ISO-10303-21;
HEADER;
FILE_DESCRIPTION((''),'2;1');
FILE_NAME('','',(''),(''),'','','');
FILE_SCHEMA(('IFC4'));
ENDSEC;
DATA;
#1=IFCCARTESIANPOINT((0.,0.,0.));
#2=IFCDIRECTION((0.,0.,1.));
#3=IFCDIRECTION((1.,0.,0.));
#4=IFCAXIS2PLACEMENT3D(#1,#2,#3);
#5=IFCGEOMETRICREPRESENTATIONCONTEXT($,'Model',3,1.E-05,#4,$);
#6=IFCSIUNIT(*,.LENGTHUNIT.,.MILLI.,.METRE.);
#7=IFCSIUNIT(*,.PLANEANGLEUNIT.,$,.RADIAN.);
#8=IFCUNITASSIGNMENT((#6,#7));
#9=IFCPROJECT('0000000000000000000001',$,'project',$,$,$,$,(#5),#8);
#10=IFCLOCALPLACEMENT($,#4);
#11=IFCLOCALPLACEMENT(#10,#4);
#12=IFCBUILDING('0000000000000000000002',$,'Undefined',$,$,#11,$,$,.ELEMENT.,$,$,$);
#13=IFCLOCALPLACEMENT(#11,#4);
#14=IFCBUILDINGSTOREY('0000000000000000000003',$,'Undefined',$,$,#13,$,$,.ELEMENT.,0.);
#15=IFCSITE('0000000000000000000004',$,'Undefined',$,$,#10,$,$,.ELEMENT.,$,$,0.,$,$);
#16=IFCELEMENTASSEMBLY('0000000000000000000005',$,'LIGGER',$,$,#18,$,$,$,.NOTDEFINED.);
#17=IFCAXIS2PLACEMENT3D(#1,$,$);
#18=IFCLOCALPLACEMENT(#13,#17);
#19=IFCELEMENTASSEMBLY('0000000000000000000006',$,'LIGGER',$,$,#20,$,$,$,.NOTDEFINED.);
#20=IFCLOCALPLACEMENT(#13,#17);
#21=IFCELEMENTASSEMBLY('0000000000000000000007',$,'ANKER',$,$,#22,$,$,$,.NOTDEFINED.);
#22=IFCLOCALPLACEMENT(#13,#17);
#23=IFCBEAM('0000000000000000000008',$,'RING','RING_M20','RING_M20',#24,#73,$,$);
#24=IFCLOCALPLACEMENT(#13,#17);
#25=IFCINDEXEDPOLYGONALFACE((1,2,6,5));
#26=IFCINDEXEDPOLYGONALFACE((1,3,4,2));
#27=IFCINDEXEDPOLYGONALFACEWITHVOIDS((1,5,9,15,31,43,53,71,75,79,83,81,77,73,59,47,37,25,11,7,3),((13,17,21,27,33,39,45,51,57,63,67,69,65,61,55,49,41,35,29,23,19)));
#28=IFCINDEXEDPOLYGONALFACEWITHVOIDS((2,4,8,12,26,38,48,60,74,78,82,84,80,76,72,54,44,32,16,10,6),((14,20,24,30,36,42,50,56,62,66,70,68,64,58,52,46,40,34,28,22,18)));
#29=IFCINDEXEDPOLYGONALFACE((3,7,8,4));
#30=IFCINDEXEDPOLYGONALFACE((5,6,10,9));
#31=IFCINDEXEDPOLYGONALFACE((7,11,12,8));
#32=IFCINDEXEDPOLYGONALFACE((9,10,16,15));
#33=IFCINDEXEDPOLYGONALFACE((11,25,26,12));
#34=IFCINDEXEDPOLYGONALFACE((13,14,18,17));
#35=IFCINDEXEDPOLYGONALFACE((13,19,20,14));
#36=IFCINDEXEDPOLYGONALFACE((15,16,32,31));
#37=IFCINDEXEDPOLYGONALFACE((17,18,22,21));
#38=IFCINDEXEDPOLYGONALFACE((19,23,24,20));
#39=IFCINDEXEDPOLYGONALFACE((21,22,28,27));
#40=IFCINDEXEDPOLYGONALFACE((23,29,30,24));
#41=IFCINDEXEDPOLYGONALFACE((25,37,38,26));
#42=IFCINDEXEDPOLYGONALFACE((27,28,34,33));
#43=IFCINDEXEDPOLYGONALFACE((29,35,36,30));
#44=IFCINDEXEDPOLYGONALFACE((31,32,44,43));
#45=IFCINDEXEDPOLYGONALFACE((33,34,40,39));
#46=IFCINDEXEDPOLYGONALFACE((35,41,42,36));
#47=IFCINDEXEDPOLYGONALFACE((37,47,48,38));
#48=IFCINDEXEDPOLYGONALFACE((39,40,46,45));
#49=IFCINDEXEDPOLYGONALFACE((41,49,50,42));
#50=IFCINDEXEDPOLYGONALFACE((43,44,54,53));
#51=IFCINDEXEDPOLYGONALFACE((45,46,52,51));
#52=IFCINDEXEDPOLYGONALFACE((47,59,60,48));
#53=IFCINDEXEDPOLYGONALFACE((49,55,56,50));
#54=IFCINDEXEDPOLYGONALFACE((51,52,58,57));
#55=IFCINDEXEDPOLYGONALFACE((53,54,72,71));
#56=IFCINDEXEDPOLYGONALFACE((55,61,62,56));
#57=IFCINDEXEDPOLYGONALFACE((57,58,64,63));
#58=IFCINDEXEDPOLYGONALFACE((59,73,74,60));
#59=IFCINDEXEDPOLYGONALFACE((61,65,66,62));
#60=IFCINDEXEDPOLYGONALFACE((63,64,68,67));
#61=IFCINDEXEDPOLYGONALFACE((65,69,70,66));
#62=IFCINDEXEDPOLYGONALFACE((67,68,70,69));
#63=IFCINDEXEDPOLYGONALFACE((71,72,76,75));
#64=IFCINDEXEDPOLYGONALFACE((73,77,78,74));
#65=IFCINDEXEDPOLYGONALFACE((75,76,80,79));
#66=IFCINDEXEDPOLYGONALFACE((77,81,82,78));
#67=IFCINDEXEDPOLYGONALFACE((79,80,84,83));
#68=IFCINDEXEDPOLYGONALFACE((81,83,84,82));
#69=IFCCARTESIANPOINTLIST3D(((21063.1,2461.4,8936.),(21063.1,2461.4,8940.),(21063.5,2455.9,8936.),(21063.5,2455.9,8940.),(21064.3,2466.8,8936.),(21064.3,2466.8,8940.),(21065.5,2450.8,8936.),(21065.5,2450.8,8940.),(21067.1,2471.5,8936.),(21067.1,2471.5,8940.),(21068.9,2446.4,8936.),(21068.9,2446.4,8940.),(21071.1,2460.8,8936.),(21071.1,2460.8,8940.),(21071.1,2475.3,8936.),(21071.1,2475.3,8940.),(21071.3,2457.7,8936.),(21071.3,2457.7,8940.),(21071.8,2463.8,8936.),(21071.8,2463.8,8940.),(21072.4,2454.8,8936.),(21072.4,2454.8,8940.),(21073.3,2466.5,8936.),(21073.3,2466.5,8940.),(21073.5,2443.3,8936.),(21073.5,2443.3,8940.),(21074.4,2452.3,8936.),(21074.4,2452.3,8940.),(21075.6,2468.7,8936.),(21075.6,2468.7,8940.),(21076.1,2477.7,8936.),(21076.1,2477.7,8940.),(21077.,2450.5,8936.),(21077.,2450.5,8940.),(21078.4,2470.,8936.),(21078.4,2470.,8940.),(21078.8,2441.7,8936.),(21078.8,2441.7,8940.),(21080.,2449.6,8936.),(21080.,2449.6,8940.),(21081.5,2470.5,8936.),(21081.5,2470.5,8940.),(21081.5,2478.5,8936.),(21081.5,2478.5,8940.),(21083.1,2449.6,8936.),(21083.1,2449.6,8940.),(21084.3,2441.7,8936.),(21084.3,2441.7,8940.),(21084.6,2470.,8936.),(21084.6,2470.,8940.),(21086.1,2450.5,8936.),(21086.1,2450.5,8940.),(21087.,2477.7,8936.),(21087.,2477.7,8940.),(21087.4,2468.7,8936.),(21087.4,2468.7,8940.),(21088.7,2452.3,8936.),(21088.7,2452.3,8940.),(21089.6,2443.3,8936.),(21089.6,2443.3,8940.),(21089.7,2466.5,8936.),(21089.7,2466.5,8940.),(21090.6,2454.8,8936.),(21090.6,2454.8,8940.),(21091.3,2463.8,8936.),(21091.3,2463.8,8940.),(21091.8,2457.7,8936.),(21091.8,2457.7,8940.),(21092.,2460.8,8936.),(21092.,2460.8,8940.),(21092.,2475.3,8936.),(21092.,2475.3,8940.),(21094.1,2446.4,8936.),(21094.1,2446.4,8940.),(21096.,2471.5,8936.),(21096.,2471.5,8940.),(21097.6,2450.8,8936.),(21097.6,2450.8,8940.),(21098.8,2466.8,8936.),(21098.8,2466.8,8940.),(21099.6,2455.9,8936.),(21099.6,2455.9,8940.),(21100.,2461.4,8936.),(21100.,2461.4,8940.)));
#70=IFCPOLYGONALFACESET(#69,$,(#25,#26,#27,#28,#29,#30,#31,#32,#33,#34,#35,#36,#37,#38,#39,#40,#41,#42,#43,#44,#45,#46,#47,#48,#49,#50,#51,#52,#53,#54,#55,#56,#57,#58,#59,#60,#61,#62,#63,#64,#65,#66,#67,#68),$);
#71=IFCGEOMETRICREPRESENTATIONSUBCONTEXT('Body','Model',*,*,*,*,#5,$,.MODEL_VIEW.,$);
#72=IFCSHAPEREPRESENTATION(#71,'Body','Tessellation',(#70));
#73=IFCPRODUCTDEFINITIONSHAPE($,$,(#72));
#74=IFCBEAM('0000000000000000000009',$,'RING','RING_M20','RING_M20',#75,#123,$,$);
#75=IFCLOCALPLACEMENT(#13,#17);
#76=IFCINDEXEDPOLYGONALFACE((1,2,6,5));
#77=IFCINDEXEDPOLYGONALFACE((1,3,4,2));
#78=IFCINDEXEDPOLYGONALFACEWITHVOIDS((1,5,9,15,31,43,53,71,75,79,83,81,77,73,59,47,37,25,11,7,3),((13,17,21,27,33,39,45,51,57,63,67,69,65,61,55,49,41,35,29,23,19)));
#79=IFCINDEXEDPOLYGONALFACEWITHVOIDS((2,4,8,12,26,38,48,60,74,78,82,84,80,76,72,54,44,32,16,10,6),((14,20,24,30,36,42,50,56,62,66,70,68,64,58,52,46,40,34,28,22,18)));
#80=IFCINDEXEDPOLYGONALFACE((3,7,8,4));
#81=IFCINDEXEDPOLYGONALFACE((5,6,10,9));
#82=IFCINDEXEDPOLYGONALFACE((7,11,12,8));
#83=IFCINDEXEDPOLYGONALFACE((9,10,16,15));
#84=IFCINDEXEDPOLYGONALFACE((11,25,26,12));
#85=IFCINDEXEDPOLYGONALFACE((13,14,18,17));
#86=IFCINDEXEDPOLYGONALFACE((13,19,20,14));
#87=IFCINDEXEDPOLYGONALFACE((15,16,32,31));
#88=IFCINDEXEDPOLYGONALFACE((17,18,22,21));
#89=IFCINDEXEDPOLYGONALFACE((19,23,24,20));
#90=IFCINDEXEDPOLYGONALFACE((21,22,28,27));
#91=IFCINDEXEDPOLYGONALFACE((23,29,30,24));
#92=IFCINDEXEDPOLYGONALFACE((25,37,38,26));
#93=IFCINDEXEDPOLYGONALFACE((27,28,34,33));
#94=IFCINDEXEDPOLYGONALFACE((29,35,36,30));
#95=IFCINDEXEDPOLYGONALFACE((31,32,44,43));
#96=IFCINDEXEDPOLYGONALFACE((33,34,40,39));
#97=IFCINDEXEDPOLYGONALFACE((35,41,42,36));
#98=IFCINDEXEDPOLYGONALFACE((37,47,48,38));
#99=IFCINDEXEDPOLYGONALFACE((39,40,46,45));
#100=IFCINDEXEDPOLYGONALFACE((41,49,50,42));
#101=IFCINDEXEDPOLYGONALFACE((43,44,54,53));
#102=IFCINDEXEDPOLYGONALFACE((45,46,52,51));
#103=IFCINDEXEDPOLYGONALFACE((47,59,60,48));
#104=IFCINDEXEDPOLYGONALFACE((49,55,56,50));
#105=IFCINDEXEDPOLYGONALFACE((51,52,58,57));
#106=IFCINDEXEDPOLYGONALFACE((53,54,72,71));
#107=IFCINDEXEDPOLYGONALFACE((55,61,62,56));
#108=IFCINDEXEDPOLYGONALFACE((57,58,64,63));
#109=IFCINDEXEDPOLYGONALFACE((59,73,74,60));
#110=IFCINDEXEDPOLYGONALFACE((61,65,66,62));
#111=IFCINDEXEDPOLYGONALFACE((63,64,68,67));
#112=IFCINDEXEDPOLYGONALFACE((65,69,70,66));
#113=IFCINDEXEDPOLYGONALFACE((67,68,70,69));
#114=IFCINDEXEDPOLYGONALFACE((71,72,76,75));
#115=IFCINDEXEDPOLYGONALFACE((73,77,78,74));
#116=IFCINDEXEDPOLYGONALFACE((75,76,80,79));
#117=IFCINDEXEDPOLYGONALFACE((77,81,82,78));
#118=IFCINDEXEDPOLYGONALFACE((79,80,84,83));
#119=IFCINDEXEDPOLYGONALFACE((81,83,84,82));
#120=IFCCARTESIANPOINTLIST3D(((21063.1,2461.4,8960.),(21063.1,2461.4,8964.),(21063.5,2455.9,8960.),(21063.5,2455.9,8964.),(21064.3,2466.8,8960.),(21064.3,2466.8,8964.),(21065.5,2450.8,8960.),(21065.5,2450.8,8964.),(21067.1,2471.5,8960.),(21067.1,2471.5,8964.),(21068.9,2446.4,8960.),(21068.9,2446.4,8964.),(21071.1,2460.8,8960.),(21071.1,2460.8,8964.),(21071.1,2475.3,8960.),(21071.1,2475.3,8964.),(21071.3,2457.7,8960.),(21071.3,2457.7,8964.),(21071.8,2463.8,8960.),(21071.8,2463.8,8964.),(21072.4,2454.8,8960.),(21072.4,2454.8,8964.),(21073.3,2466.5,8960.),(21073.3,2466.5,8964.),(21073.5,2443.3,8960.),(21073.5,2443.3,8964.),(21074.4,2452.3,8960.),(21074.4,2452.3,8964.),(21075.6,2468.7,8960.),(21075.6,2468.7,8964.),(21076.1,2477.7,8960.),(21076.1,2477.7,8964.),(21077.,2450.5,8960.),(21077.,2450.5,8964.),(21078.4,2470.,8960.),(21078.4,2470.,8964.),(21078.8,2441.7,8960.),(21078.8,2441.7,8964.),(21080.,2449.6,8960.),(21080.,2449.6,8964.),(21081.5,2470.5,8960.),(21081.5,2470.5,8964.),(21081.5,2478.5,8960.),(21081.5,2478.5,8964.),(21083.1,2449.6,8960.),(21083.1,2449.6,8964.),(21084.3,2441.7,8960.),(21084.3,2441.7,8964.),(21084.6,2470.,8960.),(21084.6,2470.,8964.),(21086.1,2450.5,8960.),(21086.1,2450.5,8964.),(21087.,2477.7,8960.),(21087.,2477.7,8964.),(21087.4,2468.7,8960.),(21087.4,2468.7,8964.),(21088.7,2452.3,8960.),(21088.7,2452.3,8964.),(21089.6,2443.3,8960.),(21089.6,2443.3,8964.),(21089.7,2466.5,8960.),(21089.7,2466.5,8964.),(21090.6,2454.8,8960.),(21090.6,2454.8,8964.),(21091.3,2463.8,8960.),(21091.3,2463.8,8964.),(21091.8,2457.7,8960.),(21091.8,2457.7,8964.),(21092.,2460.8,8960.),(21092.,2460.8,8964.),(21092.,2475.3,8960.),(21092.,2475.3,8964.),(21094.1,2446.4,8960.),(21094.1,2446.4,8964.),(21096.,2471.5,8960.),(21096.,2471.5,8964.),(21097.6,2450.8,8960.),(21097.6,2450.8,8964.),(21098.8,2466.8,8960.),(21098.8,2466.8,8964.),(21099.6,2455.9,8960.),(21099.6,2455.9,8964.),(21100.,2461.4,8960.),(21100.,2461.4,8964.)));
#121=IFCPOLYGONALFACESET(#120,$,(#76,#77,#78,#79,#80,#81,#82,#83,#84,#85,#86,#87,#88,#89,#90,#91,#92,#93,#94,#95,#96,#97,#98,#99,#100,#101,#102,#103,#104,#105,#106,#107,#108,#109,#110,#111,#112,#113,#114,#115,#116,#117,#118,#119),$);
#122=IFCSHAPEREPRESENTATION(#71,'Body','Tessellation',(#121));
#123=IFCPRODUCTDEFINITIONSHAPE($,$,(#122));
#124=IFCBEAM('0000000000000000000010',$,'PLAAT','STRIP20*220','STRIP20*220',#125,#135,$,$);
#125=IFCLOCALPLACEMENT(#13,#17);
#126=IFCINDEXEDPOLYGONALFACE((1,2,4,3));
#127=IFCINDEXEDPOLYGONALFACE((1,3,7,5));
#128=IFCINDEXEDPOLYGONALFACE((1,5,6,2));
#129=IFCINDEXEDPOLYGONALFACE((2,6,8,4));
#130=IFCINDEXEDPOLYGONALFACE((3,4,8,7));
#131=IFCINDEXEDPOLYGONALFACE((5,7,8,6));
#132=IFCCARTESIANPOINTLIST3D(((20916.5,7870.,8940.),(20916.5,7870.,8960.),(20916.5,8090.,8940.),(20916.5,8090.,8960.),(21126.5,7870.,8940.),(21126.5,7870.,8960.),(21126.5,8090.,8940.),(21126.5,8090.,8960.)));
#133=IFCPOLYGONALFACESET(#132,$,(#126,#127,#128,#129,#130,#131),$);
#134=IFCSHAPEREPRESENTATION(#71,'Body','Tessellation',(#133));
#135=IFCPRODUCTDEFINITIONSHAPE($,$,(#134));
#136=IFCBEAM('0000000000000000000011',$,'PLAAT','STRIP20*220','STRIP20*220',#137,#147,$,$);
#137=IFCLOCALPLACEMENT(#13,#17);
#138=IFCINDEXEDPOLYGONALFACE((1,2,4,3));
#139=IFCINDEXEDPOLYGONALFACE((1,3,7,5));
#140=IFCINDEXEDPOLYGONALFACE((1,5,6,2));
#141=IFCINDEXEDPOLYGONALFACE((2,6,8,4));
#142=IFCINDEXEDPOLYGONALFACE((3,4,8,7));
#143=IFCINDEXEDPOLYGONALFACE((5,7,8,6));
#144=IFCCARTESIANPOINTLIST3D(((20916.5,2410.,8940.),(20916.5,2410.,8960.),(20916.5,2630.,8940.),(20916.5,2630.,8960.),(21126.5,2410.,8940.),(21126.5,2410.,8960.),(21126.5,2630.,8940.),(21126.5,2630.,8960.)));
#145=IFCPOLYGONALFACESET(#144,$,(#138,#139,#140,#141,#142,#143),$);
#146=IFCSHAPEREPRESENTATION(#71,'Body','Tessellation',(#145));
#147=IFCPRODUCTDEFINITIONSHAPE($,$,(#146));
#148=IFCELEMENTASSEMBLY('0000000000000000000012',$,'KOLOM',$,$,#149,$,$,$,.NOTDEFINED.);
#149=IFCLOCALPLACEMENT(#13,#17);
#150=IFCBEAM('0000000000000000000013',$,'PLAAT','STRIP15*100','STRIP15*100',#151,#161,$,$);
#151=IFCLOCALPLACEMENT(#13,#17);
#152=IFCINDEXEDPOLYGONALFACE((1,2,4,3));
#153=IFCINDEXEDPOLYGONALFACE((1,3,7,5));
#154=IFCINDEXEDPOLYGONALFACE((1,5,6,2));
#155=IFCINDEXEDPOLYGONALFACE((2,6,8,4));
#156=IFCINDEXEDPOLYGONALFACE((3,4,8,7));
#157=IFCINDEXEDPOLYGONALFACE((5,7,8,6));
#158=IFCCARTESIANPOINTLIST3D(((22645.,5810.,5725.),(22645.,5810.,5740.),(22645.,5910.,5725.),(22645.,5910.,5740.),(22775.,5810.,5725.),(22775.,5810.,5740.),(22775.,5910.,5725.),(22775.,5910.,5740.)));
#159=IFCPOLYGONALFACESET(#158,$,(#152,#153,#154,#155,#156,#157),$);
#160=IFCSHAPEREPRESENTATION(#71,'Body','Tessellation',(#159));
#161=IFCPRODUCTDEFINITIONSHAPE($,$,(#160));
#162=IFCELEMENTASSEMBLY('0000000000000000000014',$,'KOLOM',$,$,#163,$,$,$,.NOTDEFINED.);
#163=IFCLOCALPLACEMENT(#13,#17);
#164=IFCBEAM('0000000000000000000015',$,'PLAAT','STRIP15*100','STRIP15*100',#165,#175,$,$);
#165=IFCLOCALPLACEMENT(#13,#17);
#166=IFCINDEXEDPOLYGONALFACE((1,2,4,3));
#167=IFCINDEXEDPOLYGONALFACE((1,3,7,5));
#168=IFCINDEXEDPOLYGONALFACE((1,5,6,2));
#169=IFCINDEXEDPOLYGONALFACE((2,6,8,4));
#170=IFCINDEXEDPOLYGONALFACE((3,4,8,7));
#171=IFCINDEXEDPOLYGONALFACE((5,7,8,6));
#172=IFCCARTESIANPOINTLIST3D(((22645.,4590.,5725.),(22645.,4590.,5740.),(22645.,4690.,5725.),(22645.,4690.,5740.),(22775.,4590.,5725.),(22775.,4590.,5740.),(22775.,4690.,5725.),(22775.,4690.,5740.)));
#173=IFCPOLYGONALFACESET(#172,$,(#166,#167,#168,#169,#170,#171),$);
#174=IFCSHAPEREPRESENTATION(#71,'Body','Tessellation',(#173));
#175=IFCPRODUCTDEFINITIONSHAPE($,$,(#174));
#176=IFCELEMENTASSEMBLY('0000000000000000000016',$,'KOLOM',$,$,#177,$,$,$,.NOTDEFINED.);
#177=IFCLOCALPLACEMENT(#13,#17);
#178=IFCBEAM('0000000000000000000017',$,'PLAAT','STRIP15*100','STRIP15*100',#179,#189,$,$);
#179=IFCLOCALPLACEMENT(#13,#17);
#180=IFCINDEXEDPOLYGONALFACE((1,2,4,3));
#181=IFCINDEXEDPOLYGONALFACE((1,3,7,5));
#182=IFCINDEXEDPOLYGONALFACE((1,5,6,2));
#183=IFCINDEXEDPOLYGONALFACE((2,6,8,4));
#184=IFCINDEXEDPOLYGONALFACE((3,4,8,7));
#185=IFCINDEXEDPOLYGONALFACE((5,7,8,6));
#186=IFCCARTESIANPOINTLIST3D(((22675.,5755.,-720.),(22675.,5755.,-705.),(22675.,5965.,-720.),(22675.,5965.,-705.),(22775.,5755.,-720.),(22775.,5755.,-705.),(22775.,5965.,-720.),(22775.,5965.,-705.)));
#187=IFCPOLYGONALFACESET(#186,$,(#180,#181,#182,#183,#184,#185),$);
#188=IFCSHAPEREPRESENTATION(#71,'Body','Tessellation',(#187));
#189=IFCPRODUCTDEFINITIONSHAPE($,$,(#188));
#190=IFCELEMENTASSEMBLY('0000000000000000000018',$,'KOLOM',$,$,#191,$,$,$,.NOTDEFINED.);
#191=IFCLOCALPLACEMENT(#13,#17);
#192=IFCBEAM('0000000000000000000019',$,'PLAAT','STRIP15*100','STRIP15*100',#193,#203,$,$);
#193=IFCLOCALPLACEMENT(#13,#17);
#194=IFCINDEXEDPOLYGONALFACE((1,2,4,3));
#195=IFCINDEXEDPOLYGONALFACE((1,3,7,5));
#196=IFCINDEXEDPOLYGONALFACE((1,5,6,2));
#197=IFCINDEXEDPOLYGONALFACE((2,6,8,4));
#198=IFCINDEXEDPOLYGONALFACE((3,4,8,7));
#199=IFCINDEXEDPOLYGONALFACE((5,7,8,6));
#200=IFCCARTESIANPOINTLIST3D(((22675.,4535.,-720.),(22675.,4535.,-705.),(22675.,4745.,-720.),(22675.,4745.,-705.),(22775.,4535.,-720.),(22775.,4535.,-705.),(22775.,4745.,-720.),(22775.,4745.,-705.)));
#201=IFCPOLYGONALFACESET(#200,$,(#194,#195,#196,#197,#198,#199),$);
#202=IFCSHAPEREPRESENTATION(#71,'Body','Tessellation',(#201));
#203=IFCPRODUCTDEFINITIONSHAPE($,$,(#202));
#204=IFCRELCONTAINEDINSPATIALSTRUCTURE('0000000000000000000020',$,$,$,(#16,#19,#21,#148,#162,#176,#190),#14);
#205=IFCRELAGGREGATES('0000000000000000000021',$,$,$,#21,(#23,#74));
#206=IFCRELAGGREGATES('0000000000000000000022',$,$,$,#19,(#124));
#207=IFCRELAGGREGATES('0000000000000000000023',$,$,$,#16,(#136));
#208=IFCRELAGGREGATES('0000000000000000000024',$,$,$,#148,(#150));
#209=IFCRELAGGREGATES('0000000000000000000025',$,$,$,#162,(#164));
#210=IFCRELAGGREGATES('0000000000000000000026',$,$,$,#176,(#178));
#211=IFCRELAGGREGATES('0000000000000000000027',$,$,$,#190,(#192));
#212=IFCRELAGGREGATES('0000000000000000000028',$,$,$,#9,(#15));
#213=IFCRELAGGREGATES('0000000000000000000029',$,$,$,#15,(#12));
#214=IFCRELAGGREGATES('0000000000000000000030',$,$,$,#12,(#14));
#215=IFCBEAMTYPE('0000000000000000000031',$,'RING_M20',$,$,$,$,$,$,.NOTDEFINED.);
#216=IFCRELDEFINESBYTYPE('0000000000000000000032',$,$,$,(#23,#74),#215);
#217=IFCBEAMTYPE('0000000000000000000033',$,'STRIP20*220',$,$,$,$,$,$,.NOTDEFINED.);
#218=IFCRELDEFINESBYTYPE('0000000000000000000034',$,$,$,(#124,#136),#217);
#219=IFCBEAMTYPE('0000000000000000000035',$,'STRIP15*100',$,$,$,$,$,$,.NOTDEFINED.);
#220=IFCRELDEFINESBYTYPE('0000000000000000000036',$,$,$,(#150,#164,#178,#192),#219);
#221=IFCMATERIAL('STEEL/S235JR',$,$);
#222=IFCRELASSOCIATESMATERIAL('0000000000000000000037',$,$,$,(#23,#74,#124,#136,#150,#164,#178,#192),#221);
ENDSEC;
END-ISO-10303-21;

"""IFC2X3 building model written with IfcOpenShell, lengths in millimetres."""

from ifc_helpers import new_model, si_unit, frame, origin_with_axes, origin_2d_with_axis, place, context, subcontext, project, spatial, rectangle, hollow_circle, extrude, material, type_object, element, aggregate, save


model = new_model("IFC2X3")

# Units and contexts
model_context = context("Model", 3, precision=1e-05, world=origin_with_axes())
body_context = subcontext(model_context, "Body", "Model", "MODEL_VIEW")
ifc_project = project(units=[si_unit("LENGTHUNIT", "METRE", prefix="MILLI"), si_unit("PLANEANGLEUNIT", "RADIAN")], contexts=[model_context])

# Site, building, storey
site_placement = place(None, origin_with_axes())
site = spatial("IfcSite", under=ifc_project, at=site_placement, Name="Undefined", CompositionType="ELEMENT", RefElevation=0.0)
building_placement = place(site_placement, origin_with_axes())
building = spatial("IfcBuilding", under=site, at=building_placement, Name="Undefined", CompositionType="ELEMENT")
storey_placement = place(building_placement, origin_with_axes())
storey = spatial("IfcBuildingStorey", under=building, at=storey_placement, Name="Undefined", CompositionType="ELEMENT", Elevation=0.0)

# Element assemblies
ifc_material = material(Name="STEEL/S235JR")
assembly_1_placement = place(storey_placement, frame((19819.0, 2520.0, 11793.5), z_axis=(0.906308, 0.0, 0.422618), x_axis=(0.422618, 0.0, -0.906308)))
assembly_1 = element("IfcElementAssembly", 1, at=assembly_1_placement, inside=storey, Name="LIGGER", PredefinedType="NOTDEFINED")
assembly_2_placement = place(storey_placement, frame((19819.0, 7980.0, 11793.5), z_axis=(0.906308, 0.0, 0.422618), x_axis=(0.422618, 0.0, -0.906308)))
assembly_2 = element("IfcElementAssembly", 2, at=assembly_2_placement, inside=storey, Name="LIGGER", PredefinedType="NOTDEFINED")

# Element assembly, beams
beam_type_1 = type_object("IfcBeamType", Name="RING_M20", PredefinedType="NOTDEFINED")
assembly_3_placement = place(storey_placement, frame((21081.5, 2460.0, 9010.0), z_axis=(0.0, 1.0, 0.0), x_axis=(0.0, 0.0, -1.0)))
assembly_3 = element("IfcElementAssembly", 3, at=assembly_3_placement, inside=storey, Name="ANKER", PredefinedType="NOTDEFINED")
beam_1_placement = place(storey_placement, frame((21081.5, 2460.0, 8940.0), z_axis=(-1.0, 0.0, 0.0), x_axis=(0.0, 0.0, -1.0)))
beam_1 = element("IfcBeam", 4, at=beam_1_placement, type_object=beam_type_1, material=ifc_material, Name="RING", Description="RING_M20", ObjectType="RING_M20", context=body_context, shape_type="SweptSolid", body=[
    extrude(hollow_circle(Radius=18.5, WallThickness=8.0, at=origin_2d_with_axis()), frame((4.0, 0.0, 0.0), z_axis=(-1.0, 0.0, 0.0), x_axis=(0.0, -1.0, 0.0)), (0.0, 0.0, 1.0), 4.0),
])
beam_2_placement = place(storey_placement, frame((21081.5, 2460.0, 8964.0), z_axis=(-1.0, 0.0, 0.0), x_axis=(0.0, 0.0, -1.0)))
beam_2 = element("IfcBeam", 5, at=beam_2_placement, type_object=beam_type_1, material=ifc_material, Name="RING", Description="RING_M20", ObjectType="RING_M20", context=body_context, shape_type="SweptSolid", body=[
    extrude(hollow_circle(Radius=18.5, WallThickness=8.0, at=origin_2d_with_axis()), frame((4.0, 0.0, 0.0), z_axis=(-1.0, 0.0, 0.0), x_axis=(0.0, -1.0, 0.0)), (0.0, 0.0, 1.0), 4.0),
])
aggregate(assembly_3, [beam_1, beam_2])

# Beams
beam_type_2 = type_object("IfcBeamType", Name="STRIP20*220", PredefinedType="NOTDEFINED")
beam_3_placement = place(storey_placement, frame((20916.5, 7980.0, 8950.0), z_axis=(0.0, 1.0, 0.0), x_axis=(1.0, 0.0, 0.0)))
beam_3 = element("IfcBeam", 6, at=beam_3_placement, type_object=beam_type_2, material=ifc_material, Name="PLAAT", Description="STRIP20*220", ObjectType="STRIP20*220", context=body_context, shape_type="SweptSolid", body=[
    extrude(rectangle(XDim=20.0, YDim=220.0, at=origin_2d_with_axis()), frame((210.0, 0.0, 0.0), z_axis=(-1.0, 0.0, 0.0), x_axis=(0.0, -1.0, 0.0)), (0.0, 0.0, 1.0), 210.0),
])
aggregate(assembly_2, [beam_3])
beam_4_placement = place(storey_placement, frame((20916.5, 2520.0, 8950.0), z_axis=(0.0, 1.0, 0.0), x_axis=(1.0, 0.0, 0.0)))
beam_4 = element("IfcBeam", 7, at=beam_4_placement, type_object=beam_type_2, material=ifc_material, Name="PLAAT", Description="STRIP20*220", ObjectType="STRIP20*220", context=body_context, shape_type="SweptSolid", body=[
    extrude(rectangle(XDim=20.0, YDim=220.0, at=origin_2d_with_axis()), frame((210.0, 0.0, 0.0), z_axis=(-1.0, 0.0, 0.0), x_axis=(0.0, -1.0, 0.0)), (0.0, 0.0, 1.0), 210.0),
])
aggregate(assembly_1, [beam_4])

# Element assemblies, beams
assembly_4_placement = place(storey_placement, frame((22725.0, 5860.0, 3000.0), z_axis=(-1.0, 0.0, 0.0), x_axis=(0.0, 0.0, 1.0)))
assembly_4 = element("IfcElementAssembly", 8, at=assembly_4_placement, inside=storey, Name="KOLOM", PredefinedType="NOTDEFINED")
beam_type_3 = type_object("IfcBeamType", Name="STRIP15*100", PredefinedType="NOTDEFINED")
beam_5_placement = place(storey_placement, frame((22775.0, 5860.0, 5732.5), z_axis=(0.0, 1.0, 0.0), x_axis=(-1.0, 0.0, 0.0)))
beam_5 = element("IfcBeam", 9, at=beam_5_placement, type_object=beam_type_3, material=ifc_material, Name="PLAAT", Description="STRIP15*100", ObjectType="STRIP15*100", context=body_context, shape_type="SweptSolid", body=[
    extrude(rectangle(XDim=15.0, YDim=100.0, at=origin_2d_with_axis()), frame((130.0, 0.0, 0.0), z_axis=(-1.0, 0.0, 0.0), x_axis=(0.0, -1.0, 0.0)), (0.0, 0.0, 1.0), 130.0),
])
aggregate(assembly_4, [beam_5])
assembly_5_placement = place(storey_placement, frame((22725.0, 4640.0, 3000.0), z_axis=(-1.0, 0.0, 0.0), x_axis=(0.0, 0.0, 1.0)))
assembly_5 = element("IfcElementAssembly", 10, at=assembly_5_placement, inside=storey, Name="KOLOM", PredefinedType="NOTDEFINED")
beam_6_placement = place(storey_placement, frame((22775.0, 4640.0, 5732.5), z_axis=(0.0, 1.0, 0.0), x_axis=(-1.0, 0.0, 0.0)))
beam_6 = element("IfcBeam", 11, at=beam_6_placement, type_object=beam_type_3, material=ifc_material, Name="PLAAT", Description="STRIP15*100", ObjectType="STRIP15*100", context=body_context, shape_type="SweptSolid", body=[
    extrude(rectangle(XDim=15.0, YDim=100.0, at=origin_2d_with_axis()), frame((130.0, 0.0, 0.0), z_axis=(-1.0, 0.0, 0.0), x_axis=(0.0, -1.0, 0.0)), (0.0, 0.0, 1.0), 130.0),
])
aggregate(assembly_5, [beam_6])
assembly_6_placement = place(storey_placement, frame((22725.0, 5860.0, -720.0), z_axis=(-1.0, 0.0, 0.0), x_axis=(0.0, 0.0, 1.0)))
assembly_6 = element("IfcElementAssembly", 12, at=assembly_6_placement, inside=storey, Name="KOLOM", PredefinedType="NOTDEFINED")
beam_7_placement = place(storey_placement, frame((22675.0, 5860.0, -712.5), z_axis=(0.0, 1.0, 0.0), x_axis=(1.0, 0.0, 0.0)))
beam_7 = element("IfcBeam", 13, at=beam_7_placement, type_object=beam_type_3, material=ifc_material, Name="PLAAT", Description="STRIP15*100", ObjectType="STRIP15*100", context=body_context, shape_type="SweptSolid", body=[
    extrude(rectangle(XDim=15.0, YDim=210.0, at=origin_2d_with_axis()), frame((100.0, 0.0, 0.0), z_axis=(-1.0, 0.0, 0.0), x_axis=(0.0, -1.0, 0.0)), (0.0, 0.0, 1.0), 100.0),
])
aggregate(assembly_6, [beam_7])
assembly_7_placement = place(storey_placement, frame((22725.0, 4640.0, -720.0), z_axis=(-1.0, 0.0, 0.0), x_axis=(0.0, 0.0, 1.0)))
assembly_7 = element("IfcElementAssembly", 14, at=assembly_7_placement, inside=storey, Name="KOLOM", PredefinedType="NOTDEFINED")
beam_8_placement = place(storey_placement, frame((22675.0, 4640.0, -712.5), z_axis=(0.0, 1.0, 0.0), x_axis=(1.0, 0.0, 0.0)))
beam_8 = element("IfcBeam", 15, at=beam_8_placement, type_object=beam_type_3, material=ifc_material, Name="PLAAT", Description="STRIP15*100", ObjectType="STRIP15*100", context=body_context, shape_type="SweptSolid", body=[
    extrude(rectangle(XDim=15.0, YDim=210.0, at=origin_2d_with_axis()), frame((100.0, 0.0, 0.0), z_axis=(-1.0, 0.0, 0.0), x_axis=(0.0, -1.0, 0.0)), (0.0, 0.0, 1.0), 100.0),
])
aggregate(assembly_7, [beam_8])

save(model, "model.ifc")
